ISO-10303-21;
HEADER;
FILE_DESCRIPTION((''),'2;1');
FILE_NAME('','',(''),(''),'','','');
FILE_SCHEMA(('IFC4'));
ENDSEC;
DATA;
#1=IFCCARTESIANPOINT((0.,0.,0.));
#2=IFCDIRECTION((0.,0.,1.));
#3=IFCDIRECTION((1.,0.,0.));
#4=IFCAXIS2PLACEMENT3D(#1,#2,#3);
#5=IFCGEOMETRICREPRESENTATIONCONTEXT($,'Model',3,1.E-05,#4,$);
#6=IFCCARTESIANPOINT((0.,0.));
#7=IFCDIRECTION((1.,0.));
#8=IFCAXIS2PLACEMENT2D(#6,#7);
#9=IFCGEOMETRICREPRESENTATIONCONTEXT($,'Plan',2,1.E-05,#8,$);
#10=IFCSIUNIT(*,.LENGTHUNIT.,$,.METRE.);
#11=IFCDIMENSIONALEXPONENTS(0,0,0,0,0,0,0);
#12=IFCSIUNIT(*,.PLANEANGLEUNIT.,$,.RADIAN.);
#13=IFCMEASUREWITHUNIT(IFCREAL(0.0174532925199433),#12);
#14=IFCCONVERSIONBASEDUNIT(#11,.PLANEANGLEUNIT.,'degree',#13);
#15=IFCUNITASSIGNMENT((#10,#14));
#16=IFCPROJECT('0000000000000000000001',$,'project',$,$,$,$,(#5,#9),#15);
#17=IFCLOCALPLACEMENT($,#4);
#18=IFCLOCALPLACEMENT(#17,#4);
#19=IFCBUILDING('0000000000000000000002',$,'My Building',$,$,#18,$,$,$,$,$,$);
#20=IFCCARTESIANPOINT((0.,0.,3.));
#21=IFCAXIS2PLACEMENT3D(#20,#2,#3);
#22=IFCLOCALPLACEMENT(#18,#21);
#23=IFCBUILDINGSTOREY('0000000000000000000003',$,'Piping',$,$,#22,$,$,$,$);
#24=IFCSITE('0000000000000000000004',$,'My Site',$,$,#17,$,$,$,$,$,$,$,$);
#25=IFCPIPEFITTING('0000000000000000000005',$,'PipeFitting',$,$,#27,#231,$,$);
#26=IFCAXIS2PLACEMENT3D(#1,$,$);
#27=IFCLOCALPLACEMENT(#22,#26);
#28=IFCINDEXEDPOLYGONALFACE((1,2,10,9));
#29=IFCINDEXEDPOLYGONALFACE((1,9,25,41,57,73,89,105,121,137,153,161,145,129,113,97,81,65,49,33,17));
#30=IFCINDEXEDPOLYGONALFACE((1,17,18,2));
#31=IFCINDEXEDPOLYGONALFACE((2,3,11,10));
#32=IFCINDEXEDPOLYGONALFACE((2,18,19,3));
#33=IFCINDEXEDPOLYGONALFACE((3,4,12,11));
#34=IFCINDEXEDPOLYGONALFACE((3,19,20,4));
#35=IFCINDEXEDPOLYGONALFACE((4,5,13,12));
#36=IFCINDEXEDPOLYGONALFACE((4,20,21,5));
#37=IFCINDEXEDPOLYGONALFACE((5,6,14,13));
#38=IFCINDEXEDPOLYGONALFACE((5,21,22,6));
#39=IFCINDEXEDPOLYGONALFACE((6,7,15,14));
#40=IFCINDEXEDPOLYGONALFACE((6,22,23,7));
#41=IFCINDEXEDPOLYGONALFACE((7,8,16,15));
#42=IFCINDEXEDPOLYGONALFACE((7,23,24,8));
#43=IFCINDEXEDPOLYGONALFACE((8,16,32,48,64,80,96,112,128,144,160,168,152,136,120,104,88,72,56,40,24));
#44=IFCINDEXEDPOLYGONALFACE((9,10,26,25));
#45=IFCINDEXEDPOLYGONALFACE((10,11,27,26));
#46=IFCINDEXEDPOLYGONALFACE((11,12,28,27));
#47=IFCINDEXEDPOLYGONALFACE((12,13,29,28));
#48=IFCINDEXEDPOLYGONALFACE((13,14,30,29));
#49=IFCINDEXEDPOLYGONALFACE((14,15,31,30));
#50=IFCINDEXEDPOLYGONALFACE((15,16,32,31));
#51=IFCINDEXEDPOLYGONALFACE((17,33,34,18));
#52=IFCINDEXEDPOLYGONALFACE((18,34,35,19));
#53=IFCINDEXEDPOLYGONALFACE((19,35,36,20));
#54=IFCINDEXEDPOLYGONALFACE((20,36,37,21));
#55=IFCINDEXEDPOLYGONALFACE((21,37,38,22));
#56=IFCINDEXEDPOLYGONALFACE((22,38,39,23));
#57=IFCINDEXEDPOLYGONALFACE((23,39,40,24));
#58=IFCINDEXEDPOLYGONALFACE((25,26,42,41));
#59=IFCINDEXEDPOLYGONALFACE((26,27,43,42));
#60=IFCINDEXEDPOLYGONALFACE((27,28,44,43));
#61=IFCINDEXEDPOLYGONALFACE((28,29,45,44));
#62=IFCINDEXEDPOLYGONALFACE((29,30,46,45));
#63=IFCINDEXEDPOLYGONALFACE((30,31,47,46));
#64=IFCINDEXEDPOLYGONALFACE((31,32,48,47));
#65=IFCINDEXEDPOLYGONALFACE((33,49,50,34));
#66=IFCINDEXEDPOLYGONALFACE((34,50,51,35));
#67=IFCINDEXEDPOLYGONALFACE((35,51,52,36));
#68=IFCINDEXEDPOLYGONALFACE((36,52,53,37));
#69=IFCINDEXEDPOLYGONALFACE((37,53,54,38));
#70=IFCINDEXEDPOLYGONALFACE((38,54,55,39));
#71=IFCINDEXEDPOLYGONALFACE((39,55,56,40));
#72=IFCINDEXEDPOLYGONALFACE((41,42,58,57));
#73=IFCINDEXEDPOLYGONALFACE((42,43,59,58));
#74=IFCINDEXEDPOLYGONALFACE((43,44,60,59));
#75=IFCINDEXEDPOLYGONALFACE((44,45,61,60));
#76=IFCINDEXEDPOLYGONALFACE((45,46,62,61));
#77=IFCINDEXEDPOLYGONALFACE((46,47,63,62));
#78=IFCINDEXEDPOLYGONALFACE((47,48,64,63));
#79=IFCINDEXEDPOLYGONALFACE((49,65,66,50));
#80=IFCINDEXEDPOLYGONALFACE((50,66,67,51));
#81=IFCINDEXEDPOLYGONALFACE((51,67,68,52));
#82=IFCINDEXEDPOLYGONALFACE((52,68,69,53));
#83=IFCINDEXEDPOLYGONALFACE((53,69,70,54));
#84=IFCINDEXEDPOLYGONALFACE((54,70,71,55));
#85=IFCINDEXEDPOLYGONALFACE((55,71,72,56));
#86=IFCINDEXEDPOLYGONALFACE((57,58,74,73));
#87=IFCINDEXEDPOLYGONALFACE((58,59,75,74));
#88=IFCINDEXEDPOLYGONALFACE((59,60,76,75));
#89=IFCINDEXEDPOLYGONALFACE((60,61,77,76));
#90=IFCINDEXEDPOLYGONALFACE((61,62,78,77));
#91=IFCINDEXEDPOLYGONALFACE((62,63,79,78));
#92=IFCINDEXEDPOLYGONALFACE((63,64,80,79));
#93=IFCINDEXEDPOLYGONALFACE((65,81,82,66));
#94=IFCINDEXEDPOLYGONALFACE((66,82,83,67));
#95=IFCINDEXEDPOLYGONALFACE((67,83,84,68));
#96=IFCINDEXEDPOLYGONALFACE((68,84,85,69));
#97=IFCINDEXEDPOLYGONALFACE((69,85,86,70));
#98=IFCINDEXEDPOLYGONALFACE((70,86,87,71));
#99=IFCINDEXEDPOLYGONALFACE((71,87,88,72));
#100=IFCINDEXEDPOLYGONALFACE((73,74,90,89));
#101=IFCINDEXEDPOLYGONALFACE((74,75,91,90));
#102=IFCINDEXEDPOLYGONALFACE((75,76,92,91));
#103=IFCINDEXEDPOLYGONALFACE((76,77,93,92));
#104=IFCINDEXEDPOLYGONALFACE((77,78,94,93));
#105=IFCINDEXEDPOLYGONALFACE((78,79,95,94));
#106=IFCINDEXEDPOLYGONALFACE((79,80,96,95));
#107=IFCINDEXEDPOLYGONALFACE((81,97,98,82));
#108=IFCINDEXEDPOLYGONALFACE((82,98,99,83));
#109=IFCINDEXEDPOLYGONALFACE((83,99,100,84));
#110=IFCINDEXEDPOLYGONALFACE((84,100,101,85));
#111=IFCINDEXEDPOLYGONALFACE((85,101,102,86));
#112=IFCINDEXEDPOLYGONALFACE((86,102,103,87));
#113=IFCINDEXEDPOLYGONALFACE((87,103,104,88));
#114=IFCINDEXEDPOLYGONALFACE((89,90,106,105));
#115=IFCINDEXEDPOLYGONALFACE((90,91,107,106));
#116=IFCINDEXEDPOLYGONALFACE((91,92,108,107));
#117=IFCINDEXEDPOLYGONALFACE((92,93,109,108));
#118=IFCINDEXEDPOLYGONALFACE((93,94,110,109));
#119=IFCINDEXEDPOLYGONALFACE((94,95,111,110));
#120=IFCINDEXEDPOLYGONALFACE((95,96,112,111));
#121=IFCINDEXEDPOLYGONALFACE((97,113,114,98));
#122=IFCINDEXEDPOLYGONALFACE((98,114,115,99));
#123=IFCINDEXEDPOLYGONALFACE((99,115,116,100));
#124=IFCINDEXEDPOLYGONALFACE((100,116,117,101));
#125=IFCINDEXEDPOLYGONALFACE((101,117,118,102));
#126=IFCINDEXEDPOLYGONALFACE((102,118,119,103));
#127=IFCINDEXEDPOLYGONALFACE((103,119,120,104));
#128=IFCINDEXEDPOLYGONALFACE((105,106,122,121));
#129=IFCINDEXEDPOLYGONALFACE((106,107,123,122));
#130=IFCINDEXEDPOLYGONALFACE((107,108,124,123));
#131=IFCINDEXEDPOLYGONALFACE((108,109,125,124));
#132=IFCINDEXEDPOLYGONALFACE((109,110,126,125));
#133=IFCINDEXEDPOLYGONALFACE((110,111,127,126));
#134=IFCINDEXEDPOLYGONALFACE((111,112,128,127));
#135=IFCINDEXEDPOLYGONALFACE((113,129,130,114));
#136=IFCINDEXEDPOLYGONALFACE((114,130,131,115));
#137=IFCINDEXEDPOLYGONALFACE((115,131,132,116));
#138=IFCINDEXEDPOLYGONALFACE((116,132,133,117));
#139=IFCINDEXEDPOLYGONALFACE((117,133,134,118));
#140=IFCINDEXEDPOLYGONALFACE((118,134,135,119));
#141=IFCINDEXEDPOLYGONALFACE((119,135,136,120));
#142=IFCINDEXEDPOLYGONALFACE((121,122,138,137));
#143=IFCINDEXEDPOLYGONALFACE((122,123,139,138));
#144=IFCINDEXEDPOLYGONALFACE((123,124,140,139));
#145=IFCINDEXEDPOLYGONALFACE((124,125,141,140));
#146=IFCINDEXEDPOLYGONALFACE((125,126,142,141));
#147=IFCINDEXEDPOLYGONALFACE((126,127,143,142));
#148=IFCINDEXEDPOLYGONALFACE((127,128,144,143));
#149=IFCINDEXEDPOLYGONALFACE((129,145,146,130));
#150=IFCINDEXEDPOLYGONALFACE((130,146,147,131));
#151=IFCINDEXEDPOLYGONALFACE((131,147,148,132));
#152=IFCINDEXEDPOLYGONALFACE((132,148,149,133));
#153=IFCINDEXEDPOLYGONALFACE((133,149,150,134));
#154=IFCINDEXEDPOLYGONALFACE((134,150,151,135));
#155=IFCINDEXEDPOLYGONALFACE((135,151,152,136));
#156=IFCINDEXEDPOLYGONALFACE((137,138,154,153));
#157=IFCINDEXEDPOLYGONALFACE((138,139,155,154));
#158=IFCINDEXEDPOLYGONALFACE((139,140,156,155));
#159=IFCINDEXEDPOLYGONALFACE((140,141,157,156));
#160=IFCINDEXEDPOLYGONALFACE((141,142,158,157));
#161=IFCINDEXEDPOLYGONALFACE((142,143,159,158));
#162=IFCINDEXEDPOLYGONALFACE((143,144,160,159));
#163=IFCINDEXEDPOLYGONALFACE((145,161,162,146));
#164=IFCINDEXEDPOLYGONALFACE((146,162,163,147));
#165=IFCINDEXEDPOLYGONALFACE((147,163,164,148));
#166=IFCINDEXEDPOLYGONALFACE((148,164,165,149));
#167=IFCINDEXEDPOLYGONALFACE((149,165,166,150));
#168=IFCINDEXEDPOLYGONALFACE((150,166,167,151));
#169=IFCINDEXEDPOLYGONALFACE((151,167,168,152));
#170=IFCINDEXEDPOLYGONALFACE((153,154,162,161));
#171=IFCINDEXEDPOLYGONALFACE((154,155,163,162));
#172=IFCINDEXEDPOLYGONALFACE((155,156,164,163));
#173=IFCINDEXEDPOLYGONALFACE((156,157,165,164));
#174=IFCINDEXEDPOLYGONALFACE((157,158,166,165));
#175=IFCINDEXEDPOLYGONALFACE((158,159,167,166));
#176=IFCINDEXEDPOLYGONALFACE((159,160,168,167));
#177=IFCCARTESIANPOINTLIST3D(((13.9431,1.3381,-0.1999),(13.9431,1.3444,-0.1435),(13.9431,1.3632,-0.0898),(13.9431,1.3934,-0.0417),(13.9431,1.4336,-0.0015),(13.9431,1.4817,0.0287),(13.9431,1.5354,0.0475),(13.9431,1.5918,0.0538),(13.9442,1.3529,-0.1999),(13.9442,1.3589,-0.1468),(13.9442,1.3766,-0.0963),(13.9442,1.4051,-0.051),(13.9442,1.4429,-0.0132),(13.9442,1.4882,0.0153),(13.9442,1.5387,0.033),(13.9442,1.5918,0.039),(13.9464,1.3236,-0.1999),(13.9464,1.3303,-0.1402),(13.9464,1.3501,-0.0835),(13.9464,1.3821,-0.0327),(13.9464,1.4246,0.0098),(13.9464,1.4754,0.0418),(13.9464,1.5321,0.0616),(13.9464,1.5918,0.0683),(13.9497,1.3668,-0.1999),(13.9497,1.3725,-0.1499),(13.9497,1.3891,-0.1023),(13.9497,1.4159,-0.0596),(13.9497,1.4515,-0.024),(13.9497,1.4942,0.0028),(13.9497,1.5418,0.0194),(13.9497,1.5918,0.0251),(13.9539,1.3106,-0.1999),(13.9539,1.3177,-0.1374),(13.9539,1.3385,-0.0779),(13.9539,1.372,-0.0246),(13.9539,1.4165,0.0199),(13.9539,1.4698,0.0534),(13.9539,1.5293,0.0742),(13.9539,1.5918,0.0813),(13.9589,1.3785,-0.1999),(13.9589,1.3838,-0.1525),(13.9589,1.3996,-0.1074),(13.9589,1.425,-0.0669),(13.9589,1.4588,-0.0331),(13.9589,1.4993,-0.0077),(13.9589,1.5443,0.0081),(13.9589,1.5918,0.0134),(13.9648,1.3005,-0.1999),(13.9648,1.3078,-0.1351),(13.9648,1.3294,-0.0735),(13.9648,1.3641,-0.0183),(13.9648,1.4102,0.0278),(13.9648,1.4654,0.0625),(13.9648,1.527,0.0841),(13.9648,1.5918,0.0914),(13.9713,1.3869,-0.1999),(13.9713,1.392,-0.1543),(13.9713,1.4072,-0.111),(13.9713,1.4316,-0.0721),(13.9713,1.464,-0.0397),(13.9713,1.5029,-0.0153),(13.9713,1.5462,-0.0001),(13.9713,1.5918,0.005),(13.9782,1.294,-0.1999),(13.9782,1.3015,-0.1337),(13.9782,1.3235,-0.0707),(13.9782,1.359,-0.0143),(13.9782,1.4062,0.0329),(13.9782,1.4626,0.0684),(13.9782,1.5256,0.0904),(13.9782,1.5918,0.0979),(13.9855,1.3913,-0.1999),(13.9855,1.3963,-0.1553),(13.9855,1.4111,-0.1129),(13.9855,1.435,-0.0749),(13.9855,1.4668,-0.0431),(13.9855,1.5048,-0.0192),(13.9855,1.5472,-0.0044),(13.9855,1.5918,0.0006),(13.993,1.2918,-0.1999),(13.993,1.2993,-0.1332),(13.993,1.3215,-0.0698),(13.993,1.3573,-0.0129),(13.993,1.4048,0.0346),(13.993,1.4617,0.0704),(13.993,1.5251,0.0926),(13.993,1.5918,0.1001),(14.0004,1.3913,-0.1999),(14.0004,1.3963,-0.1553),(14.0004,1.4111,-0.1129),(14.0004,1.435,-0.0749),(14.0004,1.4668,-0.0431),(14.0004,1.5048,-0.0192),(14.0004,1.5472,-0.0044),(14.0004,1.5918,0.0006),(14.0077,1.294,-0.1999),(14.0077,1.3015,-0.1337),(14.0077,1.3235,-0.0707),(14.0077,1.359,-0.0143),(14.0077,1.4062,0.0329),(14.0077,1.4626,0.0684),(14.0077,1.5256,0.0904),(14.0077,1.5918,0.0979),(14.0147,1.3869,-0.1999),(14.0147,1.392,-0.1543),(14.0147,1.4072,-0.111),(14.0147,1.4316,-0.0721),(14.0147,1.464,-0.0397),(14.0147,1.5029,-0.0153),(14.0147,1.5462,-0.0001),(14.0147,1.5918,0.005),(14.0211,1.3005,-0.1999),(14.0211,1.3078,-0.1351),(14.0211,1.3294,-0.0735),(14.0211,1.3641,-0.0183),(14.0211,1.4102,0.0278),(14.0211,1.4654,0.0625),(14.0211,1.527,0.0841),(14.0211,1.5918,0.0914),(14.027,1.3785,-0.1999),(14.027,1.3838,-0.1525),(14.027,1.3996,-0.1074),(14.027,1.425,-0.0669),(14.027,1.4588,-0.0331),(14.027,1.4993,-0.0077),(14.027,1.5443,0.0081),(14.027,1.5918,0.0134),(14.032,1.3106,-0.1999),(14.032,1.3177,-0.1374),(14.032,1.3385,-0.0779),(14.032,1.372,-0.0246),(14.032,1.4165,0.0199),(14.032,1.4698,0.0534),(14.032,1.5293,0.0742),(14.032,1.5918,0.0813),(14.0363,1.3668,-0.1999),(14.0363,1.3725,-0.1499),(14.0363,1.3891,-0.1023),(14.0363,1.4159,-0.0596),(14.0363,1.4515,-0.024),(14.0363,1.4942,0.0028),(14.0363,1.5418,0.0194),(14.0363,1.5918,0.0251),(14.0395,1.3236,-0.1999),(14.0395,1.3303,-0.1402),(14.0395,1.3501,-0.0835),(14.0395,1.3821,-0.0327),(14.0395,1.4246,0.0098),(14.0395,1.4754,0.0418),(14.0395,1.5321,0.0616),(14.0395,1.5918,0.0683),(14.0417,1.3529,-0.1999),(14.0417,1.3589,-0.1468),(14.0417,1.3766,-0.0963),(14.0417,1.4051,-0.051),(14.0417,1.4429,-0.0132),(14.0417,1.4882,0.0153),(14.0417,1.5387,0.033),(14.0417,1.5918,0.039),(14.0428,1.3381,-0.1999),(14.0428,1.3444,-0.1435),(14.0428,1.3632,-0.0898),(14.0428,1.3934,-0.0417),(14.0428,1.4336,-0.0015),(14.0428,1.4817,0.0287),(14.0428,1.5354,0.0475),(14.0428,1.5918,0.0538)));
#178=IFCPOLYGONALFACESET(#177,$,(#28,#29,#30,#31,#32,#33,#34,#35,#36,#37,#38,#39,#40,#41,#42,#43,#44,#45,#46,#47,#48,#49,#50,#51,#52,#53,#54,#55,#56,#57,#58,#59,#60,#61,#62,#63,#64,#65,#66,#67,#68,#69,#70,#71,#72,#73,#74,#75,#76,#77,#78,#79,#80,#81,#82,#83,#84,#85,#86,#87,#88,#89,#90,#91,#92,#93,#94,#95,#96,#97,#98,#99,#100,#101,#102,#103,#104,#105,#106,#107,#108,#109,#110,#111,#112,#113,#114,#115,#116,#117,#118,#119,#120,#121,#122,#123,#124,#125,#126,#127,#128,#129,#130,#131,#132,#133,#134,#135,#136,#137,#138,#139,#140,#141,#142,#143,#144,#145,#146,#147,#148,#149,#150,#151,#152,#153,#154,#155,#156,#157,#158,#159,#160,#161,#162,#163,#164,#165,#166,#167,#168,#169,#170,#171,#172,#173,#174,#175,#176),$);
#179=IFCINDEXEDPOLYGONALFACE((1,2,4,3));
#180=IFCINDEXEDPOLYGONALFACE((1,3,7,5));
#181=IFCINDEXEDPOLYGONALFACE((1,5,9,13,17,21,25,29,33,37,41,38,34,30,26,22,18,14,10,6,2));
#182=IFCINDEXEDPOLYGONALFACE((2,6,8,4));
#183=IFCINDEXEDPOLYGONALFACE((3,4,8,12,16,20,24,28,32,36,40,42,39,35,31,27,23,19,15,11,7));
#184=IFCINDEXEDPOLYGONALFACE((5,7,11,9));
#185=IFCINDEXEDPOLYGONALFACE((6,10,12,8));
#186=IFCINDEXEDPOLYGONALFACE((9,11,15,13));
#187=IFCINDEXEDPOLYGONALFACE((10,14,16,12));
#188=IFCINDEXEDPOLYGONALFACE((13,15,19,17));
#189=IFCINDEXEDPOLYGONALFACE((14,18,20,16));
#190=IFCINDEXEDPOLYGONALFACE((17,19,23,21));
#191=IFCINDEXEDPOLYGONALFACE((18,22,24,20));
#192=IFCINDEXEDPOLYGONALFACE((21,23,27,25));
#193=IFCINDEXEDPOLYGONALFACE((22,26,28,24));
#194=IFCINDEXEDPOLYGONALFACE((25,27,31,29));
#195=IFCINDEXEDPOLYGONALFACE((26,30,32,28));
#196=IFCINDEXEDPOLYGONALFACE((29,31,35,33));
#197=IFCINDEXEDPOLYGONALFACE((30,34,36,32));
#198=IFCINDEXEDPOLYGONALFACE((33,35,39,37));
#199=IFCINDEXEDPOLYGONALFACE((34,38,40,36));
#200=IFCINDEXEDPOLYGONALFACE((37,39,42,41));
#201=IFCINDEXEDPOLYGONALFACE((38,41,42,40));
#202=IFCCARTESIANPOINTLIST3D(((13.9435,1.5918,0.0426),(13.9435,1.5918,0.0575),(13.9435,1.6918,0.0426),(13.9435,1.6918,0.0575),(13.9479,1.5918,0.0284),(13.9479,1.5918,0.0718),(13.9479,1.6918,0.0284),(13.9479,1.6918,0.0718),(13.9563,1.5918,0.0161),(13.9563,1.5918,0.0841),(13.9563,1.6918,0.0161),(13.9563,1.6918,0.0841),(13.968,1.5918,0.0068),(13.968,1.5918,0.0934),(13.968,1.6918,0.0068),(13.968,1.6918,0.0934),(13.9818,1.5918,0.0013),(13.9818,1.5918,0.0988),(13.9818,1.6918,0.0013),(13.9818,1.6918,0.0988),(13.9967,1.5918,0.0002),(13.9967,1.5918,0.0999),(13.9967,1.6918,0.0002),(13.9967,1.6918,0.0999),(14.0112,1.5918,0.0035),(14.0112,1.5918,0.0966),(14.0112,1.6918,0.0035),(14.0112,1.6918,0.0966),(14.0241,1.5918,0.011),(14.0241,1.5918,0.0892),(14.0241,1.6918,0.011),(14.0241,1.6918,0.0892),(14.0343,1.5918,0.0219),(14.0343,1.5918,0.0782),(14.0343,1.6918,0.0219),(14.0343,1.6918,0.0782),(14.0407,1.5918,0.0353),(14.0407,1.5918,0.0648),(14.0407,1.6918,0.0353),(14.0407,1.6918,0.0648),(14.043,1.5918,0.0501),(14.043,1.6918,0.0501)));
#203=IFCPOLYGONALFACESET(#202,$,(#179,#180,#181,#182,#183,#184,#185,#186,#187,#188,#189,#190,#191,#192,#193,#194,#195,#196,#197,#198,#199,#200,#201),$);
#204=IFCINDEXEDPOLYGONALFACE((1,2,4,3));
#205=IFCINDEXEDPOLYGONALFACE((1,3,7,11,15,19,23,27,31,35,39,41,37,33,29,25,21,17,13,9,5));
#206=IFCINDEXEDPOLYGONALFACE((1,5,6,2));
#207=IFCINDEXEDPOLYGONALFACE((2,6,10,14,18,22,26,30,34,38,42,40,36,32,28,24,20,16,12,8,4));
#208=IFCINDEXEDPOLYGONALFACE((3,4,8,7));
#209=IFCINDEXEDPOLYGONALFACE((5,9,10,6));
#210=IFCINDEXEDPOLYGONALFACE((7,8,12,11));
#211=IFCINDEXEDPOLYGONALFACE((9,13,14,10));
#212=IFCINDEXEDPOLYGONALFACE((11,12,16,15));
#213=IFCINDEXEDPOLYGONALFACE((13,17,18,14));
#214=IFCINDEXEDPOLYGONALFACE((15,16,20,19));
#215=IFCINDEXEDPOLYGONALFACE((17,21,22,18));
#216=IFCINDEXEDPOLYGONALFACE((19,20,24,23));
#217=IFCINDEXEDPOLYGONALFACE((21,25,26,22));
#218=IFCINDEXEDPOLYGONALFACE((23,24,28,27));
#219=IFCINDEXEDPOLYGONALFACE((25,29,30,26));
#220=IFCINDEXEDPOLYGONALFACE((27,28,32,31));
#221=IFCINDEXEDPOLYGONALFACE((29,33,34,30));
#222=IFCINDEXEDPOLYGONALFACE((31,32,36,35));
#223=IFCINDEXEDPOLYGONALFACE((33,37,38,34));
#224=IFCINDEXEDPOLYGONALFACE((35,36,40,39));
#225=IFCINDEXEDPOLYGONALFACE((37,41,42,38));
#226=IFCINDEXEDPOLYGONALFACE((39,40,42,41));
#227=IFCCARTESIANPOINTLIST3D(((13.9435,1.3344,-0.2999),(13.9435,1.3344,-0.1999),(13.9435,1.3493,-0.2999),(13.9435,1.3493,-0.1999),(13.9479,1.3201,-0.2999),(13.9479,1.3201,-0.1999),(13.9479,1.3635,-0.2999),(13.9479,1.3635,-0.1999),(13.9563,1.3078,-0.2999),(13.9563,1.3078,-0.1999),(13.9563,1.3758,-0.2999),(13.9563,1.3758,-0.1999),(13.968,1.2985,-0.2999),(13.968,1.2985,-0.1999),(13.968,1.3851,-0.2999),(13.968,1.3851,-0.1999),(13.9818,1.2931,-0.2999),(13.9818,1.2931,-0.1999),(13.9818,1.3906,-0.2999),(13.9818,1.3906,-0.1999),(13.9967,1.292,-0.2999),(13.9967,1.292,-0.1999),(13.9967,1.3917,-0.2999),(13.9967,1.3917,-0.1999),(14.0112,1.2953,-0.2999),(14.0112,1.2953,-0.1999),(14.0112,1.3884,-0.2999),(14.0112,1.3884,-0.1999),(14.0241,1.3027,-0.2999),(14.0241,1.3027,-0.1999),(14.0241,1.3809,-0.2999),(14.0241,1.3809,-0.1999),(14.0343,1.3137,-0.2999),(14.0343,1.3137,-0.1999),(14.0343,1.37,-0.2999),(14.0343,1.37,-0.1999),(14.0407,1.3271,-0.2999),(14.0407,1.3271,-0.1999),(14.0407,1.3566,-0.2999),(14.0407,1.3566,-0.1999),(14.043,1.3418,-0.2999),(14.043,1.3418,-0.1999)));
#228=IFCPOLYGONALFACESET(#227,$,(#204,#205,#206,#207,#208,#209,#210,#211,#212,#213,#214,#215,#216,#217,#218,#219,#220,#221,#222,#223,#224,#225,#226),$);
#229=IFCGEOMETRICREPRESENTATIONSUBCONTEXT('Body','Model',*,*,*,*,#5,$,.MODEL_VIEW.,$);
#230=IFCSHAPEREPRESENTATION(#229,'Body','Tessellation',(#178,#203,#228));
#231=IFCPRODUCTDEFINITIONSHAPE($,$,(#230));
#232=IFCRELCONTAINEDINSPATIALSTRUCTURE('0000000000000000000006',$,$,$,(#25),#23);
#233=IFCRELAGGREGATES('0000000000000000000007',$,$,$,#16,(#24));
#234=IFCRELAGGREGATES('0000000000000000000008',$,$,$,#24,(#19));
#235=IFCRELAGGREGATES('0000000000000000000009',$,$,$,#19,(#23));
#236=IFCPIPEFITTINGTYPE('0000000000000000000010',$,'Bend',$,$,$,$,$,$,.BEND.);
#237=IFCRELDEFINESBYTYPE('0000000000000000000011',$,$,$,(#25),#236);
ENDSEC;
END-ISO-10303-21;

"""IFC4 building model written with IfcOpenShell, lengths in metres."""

from ifc_helpers import new_model, entity, si_unit, converted_unit, frame, origin_with_axes, origin_2d_with_axis, place, context, subcontext, project, spatial, circle, extrude, source, transform, mapped, type_object, type_shapes, element, save


model = new_model("IFC4")

# Units and contexts
model_context = context("Model", 3, precision=1e-05, world=origin_with_axes())
plan_context = context("Plan", 2, precision=1e-05, world=origin_2d_with_axis())
body_context = subcontext(model_context, "Body", "Model", "MODEL_VIEW")
ifc_project = project(units=[si_unit("LENGTHUNIT", "METRE"), converted_unit("PLANEANGLEUNIT", "degree", entity("IfcReal", 0.0174532925199433), si_unit("PLANEANGLEUNIT", "RADIAN"), dimensions=[0, 0, 0, 0, 0, 0, 0])], contexts=[model_context, plan_context])

# Site, building, storey
site_placement = place(None, origin_with_axes())
site = spatial("IfcSite", under=ifc_project, at=site_placement, Name="My Site")
building_placement = place(site_placement, origin_with_axes())
building = spatial("IfcBuilding", under=site, at=building_placement, Name="My Building")
storey_placement = place(building_placement, frame((0.0, 0.0, 3.0), z_axis=(0.0, 0.0, 1.0), x_axis=(1.0, 0.0, 0.0)))
storey = spatial("IfcBuildingStorey", under=building, at=storey_placement, Name="Piping")

# Pipe fitting
pipe_fitting_type_1 = type_object("IfcPipeFittingType", Name="Bend", PredefinedType="BEND")
shared_shape = source(origin_with_axes(), body_context, "Body", "SolidModel", [
    entity("IfcSweptDiskSolid", entity("IfcIndexedPolyCurve", entity("IfcCartesianPointList3D", [[0.0, 0.0, 0.1], [0.0, -0.0732, 0.2768], [0.0, -0.25, 0.35]]), [entity("IfcArcIndex", [1, 2, 3])]), 0.05),
    extrude(circle(Radius=0.05), origin_with_axes(), (0.0, 0.0, 1.0), 0.1),
    extrude(circle(Radius=0.05), frame((0.0, -0.25, 0.35), z_axis=(0.0, -1.0, -0.000003), x_axis=(1.0, 0.0, 0.0)), (0.0, 0.0, 1.0), 0.1),
])
type_shapes(pipe_fitting_type_1, [shared_shape])
for number, where, z_axis, x_axis, name in (
    (1, (13.993, 1.6918, 0.0501), (0.0, -1.0, 0.0), (1.0, 0.0, 0.0), "PipeFitting"),
):
    element("IfcPipeFitting", number, at=place(storey_placement, frame(where, z_axis=z_axis, x_axis=x_axis)), inside=storey, type_object=pipe_fitting_type_1, Name=name, context=body_context, shape_type="MappedRepresentation", body=[
        mapped(shared_shape, transform((0.0, 0.0, 0.0), x_axis=(1.0, 0.0, 0.0), y_axis=(0.0, 1.0, 0.0), z_axis=(0.0, 0.0, 1.0), scale=1.0)),
    ])

save(model, "model.ifc")
